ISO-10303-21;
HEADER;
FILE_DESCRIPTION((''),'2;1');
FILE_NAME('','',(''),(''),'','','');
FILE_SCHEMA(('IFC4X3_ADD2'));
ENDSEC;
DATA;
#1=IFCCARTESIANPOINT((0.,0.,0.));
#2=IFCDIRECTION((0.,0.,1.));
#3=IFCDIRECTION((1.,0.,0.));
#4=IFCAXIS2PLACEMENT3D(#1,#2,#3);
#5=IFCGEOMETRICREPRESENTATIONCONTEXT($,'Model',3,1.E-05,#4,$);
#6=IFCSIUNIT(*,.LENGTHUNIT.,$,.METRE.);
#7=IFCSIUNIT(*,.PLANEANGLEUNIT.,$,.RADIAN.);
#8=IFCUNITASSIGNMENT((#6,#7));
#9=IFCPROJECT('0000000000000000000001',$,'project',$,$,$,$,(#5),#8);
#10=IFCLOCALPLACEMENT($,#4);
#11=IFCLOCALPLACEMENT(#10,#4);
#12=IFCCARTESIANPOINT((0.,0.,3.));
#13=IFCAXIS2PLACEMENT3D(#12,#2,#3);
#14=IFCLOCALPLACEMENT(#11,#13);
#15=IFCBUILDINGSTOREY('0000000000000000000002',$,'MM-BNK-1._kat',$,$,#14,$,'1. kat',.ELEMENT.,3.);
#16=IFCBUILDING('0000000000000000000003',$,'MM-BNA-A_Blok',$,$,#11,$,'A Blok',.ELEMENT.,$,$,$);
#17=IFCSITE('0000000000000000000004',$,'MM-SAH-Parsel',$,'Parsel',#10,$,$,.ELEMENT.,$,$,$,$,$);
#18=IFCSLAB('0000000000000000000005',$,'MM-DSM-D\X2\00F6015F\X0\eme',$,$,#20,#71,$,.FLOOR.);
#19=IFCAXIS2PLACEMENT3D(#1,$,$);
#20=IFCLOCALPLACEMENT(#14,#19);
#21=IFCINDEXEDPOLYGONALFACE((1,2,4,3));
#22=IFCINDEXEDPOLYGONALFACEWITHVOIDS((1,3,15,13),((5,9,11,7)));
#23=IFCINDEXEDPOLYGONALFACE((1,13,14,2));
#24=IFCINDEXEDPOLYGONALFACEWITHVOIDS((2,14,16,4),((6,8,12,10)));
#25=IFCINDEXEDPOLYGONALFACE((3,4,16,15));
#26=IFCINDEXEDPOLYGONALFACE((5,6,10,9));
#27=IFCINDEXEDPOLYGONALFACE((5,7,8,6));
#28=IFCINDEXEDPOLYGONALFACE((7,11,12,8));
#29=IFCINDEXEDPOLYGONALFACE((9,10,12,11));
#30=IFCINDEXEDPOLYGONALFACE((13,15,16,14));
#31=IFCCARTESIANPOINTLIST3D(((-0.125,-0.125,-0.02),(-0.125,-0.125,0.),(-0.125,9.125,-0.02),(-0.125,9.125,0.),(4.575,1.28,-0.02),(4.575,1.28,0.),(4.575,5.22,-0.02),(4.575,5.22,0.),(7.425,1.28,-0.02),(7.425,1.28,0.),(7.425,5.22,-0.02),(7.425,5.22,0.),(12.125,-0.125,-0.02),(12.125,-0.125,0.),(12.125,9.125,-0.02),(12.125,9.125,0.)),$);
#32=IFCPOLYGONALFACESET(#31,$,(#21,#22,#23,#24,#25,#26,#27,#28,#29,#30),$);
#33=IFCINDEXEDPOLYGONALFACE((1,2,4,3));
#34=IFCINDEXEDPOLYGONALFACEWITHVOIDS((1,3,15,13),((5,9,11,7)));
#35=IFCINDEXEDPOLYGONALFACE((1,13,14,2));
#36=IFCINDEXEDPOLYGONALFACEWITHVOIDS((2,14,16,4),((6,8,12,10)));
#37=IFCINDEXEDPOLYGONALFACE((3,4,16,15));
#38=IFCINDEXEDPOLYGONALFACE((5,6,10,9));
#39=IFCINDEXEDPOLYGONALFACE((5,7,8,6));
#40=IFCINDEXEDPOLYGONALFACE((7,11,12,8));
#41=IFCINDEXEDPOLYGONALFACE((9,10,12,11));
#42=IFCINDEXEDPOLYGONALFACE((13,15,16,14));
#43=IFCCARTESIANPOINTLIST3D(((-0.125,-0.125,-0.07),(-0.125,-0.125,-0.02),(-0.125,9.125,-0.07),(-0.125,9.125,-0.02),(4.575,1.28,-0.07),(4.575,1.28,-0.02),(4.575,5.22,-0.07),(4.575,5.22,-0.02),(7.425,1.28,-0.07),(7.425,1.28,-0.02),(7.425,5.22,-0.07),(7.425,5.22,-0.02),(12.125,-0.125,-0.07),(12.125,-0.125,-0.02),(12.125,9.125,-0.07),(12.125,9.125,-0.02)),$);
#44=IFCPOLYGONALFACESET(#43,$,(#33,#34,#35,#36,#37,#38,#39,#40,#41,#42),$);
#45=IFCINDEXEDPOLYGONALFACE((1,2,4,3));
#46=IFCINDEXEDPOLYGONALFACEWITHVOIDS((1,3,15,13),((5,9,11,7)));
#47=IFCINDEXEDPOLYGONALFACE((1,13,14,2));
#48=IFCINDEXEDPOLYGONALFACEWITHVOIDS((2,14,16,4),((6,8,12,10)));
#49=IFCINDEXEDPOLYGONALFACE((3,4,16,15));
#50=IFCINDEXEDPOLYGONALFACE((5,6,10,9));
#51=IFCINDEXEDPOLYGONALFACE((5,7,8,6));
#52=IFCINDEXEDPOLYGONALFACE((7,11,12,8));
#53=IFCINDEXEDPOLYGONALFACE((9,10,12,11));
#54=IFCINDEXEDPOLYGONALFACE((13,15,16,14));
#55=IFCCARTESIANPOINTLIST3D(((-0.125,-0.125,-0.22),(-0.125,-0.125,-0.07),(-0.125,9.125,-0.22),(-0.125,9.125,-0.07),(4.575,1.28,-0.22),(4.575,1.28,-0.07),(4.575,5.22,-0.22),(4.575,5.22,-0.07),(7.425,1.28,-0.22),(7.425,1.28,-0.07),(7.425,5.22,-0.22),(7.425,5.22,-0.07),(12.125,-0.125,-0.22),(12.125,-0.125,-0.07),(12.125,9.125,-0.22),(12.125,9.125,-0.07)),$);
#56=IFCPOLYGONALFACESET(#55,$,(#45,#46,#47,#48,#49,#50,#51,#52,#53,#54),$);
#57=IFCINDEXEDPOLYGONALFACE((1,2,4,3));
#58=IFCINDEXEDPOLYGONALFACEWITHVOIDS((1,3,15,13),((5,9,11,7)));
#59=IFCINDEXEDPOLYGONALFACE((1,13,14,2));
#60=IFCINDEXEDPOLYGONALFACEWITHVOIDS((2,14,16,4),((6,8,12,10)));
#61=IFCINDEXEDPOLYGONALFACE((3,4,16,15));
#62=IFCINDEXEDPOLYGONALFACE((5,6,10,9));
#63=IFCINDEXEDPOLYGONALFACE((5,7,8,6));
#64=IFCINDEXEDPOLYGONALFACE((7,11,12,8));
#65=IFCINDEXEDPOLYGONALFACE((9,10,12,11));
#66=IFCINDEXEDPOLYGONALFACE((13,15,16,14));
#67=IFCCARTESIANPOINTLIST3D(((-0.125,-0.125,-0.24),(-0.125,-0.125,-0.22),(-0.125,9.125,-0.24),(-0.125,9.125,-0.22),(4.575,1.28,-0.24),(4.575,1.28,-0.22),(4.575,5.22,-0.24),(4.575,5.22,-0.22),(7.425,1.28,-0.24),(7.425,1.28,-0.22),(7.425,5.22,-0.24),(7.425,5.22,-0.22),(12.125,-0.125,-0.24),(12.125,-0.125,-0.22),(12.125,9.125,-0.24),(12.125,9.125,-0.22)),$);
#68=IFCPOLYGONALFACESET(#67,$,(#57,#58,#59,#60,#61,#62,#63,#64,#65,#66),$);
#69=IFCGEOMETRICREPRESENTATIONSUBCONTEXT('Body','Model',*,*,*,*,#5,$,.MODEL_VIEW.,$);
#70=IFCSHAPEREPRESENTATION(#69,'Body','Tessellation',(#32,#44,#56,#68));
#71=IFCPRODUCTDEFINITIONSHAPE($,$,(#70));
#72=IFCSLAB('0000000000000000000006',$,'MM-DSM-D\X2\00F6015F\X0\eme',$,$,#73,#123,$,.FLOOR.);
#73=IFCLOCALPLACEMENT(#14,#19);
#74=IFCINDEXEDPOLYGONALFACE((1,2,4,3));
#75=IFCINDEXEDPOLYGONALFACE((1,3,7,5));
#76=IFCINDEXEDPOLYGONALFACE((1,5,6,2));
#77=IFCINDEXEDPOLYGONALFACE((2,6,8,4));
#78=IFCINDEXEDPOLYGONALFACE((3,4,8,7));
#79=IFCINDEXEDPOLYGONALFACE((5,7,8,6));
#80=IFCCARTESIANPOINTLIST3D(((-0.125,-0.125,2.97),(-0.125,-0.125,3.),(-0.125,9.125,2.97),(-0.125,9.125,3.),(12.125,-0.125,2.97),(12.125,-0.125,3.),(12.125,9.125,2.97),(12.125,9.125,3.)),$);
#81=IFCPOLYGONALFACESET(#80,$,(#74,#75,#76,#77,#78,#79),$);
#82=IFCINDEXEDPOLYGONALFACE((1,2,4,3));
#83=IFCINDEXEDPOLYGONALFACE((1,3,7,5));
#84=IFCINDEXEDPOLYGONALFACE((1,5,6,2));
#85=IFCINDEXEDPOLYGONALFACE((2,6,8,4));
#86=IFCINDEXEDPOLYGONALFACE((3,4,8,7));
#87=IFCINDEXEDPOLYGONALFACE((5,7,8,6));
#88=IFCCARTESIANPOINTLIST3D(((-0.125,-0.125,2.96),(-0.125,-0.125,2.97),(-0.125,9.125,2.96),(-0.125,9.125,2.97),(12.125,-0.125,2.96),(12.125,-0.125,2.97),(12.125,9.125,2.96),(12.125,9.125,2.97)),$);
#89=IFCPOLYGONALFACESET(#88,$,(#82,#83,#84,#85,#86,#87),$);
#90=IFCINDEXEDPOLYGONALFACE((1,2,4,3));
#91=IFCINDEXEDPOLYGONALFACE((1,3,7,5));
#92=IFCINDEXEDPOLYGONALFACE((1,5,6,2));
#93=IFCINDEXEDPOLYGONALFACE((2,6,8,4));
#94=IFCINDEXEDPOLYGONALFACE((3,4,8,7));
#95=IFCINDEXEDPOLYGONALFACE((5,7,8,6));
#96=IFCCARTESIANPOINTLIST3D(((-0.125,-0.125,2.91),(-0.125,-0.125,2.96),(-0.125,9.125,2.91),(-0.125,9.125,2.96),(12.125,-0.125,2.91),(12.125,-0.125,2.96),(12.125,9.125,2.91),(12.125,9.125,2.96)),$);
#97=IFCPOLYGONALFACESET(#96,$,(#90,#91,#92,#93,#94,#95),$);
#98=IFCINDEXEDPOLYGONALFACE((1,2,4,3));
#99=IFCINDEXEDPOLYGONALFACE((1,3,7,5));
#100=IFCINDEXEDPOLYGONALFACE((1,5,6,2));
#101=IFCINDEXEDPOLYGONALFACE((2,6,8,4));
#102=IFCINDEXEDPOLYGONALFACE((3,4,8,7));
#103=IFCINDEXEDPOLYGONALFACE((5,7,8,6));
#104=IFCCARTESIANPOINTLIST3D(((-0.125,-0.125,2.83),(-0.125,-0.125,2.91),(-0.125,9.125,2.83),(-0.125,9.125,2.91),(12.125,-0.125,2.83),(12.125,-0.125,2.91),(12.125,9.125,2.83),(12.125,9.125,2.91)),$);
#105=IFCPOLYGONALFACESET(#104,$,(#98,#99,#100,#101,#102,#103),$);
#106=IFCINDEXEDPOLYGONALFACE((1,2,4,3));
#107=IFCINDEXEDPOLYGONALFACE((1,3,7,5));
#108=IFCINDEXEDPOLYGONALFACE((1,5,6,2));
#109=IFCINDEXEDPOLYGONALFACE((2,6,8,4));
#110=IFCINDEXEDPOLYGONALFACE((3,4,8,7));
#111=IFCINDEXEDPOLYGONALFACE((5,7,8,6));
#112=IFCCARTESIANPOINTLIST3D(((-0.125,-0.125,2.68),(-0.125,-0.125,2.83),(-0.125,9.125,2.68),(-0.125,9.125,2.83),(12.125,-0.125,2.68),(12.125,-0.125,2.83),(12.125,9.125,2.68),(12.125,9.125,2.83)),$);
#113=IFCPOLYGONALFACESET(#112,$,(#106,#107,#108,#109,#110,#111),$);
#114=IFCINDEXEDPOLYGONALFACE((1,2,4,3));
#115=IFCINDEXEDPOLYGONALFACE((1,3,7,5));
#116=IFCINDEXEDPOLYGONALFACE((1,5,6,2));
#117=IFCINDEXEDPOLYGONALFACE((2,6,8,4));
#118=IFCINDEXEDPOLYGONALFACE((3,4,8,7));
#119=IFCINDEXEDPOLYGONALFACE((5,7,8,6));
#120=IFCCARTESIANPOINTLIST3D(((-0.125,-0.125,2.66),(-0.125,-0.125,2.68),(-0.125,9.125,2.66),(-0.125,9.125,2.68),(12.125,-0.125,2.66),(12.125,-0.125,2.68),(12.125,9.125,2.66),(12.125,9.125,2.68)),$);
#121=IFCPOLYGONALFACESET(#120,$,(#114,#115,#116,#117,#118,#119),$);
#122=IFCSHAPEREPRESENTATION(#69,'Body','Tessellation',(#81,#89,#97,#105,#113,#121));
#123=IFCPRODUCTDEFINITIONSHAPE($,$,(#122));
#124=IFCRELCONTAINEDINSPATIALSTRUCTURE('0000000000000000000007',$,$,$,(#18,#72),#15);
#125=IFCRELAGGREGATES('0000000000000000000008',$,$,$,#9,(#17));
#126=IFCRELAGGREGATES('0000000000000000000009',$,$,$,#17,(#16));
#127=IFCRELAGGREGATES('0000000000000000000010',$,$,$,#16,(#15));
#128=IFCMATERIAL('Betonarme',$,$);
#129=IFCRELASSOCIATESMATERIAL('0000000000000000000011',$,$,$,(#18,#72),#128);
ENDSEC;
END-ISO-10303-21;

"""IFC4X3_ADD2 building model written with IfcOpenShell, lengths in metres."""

from ifc_helpers import new_model, si_unit, frame, origin_with_axes, place, context, subcontext, project, spatial, polyline, outline, extrude, material, element, save


model = new_model("IFC4X3_ADD2")

# Units and contexts
model_context = context("Model", 3, precision=1e-05, world=origin_with_axes())
body_context = subcontext(model_context, "Body", "Model", "MODEL_VIEW")
ifc_project = project(units=[si_unit("LENGTHUNIT", "METRE"), si_unit("PLANEANGLEUNIT", "RADIAN")], contexts=[model_context])

# Site, building, storey
site_placement = place(None, origin_with_axes())
site = spatial("IfcSite", under=ifc_project, at=site_placement, Name="MM-SAH-Parsel", ObjectType="Parsel", CompositionType="ELEMENT")
building_placement = place(site_placement, origin_with_axes())
building = spatial("IfcBuilding", under=site, at=building_placement, Name="MM-BNA-A_Blok", LongName="A Blok", CompositionType="ELEMENT")
storey_placement = place(building_placement, frame((0.0, 0.0, 3.0), z_axis=(0.0, 0.0, 1.0), x_axis=(1.0, 0.0, 0.0)))
storey = spatial("IfcBuildingStorey", under=building, at=storey_placement, Name="MM-BNK-1._kat", LongName="1. kat", CompositionType="ELEMENT", Elevation=3.0)

# Shared definitions
ifc_material_1 = material(Name="Betonarme")

# Slab, opening
slab_1_placement = place(storey_placement, origin_with_axes())
slab_1 = element("IfcSlab", 1, at=slab_1_placement, inside=storey, material=ifc_material_1, Name="MM-DSM-Döşeme", PredefinedType="FLOOR", context=body_context, shape_type="SweptSolid", body=[
    extrude(outline(polyline([(-0.125, -0.125), (12.125, -0.125), (12.125, 9.125), (-0.125, 9.125), (-0.125, -0.125)])), frame((0.0, 0.0, -0.02)), (0.0, 0.0, 1.0), 0.02),
    extrude(outline(polyline([(-0.125, -0.125), (12.125, -0.125), (12.125, 9.125), (-0.125, 9.125), (-0.125, -0.125)])), frame((0.0, 0.0, -0.07)), (0.0, 0.0, 1.0), 0.05),
    extrude(outline(polyline([(-0.125, -0.125), (12.125, -0.125), (12.125, 9.125), (-0.125, 9.125), (-0.125, -0.125)])), frame((0.0, 0.0, -0.22)), (0.0, 0.0, 1.0), 0.15),
    extrude(outline(polyline([(-0.125, -0.125), (12.125, -0.125), (12.125, 9.125), (-0.125, 9.125), (-0.125, -0.125)])), frame((0.0, 0.0, -0.24)), (0.0, 0.0, 1.0), 0.02),
])
opening_1_placement = place(storey_placement, origin_with_axes())
element("IfcOpeningElement", 2, at=opening_1_placement, cuts=slab_1, PredefinedType="OPENING", context=body_context, shape_type="SweptSolid", body=[
    extrude(outline(polyline([(4.575, 1.28), (4.575, 5.22), (7.425, 5.22), (7.425, 1.28), (4.575, 1.28)])), frame((0.0, 0.0, -0.24)), (0.0, 0.0, 1.0), 0.24),
])

# Slab
slab_2_placement = place(storey_placement, origin_with_axes())
element("IfcSlab", 3, at=slab_2_placement, inside=storey, material=ifc_material_1, Name="MM-DSM-Döşeme", PredefinedType="FLOOR", context=body_context, shape_type="SweptSolid", body=[
    extrude(outline(polyline([(-0.125, -0.125), (12.125, -0.125), (12.125, 9.125), (-0.125, 9.125), (-0.125, -0.125)])), frame((0.0, 0.0, 2.97)), (0.0, 0.0, 1.0), 0.03),
    extrude(outline(polyline([(-0.125, -0.125), (12.125, -0.125), (12.125, 9.125), (-0.125, 9.125), (-0.125, -0.125)])), frame((0.0, 0.0, 2.96)), (0.0, 0.0, 1.0), 0.01),
    extrude(outline(polyline([(-0.125, -0.125), (12.125, -0.125), (12.125, 9.125), (-0.125, 9.125), (-0.125, -0.125)])), frame((0.0, 0.0, 2.91)), (0.0, 0.0, 1.0), 0.05),
    extrude(outline(polyline([(-0.125, -0.125), (12.125, -0.125), (12.125, 9.125), (-0.125, 9.125), (-0.125, -0.125)])), frame((0.0, 0.0, 2.83)), (0.0, 0.0, 1.0), 0.08),
    extrude(outline(polyline([(-0.125, -0.125), (12.125, -0.125), (12.125, 9.125), (-0.125, 9.125), (-0.125, -0.125)])), frame((0.0, 0.0, 2.68)), (0.0, 0.0, 1.0), 0.15),
    extrude(outline(polyline([(-0.125, -0.125), (12.125, -0.125), (12.125, 9.125), (-0.125, 9.125), (-0.125, -0.125)])), frame((0.0, 0.0, 2.66)), (0.0, 0.0, 1.0), 0.02),
])

save(model, "model.ifc")
